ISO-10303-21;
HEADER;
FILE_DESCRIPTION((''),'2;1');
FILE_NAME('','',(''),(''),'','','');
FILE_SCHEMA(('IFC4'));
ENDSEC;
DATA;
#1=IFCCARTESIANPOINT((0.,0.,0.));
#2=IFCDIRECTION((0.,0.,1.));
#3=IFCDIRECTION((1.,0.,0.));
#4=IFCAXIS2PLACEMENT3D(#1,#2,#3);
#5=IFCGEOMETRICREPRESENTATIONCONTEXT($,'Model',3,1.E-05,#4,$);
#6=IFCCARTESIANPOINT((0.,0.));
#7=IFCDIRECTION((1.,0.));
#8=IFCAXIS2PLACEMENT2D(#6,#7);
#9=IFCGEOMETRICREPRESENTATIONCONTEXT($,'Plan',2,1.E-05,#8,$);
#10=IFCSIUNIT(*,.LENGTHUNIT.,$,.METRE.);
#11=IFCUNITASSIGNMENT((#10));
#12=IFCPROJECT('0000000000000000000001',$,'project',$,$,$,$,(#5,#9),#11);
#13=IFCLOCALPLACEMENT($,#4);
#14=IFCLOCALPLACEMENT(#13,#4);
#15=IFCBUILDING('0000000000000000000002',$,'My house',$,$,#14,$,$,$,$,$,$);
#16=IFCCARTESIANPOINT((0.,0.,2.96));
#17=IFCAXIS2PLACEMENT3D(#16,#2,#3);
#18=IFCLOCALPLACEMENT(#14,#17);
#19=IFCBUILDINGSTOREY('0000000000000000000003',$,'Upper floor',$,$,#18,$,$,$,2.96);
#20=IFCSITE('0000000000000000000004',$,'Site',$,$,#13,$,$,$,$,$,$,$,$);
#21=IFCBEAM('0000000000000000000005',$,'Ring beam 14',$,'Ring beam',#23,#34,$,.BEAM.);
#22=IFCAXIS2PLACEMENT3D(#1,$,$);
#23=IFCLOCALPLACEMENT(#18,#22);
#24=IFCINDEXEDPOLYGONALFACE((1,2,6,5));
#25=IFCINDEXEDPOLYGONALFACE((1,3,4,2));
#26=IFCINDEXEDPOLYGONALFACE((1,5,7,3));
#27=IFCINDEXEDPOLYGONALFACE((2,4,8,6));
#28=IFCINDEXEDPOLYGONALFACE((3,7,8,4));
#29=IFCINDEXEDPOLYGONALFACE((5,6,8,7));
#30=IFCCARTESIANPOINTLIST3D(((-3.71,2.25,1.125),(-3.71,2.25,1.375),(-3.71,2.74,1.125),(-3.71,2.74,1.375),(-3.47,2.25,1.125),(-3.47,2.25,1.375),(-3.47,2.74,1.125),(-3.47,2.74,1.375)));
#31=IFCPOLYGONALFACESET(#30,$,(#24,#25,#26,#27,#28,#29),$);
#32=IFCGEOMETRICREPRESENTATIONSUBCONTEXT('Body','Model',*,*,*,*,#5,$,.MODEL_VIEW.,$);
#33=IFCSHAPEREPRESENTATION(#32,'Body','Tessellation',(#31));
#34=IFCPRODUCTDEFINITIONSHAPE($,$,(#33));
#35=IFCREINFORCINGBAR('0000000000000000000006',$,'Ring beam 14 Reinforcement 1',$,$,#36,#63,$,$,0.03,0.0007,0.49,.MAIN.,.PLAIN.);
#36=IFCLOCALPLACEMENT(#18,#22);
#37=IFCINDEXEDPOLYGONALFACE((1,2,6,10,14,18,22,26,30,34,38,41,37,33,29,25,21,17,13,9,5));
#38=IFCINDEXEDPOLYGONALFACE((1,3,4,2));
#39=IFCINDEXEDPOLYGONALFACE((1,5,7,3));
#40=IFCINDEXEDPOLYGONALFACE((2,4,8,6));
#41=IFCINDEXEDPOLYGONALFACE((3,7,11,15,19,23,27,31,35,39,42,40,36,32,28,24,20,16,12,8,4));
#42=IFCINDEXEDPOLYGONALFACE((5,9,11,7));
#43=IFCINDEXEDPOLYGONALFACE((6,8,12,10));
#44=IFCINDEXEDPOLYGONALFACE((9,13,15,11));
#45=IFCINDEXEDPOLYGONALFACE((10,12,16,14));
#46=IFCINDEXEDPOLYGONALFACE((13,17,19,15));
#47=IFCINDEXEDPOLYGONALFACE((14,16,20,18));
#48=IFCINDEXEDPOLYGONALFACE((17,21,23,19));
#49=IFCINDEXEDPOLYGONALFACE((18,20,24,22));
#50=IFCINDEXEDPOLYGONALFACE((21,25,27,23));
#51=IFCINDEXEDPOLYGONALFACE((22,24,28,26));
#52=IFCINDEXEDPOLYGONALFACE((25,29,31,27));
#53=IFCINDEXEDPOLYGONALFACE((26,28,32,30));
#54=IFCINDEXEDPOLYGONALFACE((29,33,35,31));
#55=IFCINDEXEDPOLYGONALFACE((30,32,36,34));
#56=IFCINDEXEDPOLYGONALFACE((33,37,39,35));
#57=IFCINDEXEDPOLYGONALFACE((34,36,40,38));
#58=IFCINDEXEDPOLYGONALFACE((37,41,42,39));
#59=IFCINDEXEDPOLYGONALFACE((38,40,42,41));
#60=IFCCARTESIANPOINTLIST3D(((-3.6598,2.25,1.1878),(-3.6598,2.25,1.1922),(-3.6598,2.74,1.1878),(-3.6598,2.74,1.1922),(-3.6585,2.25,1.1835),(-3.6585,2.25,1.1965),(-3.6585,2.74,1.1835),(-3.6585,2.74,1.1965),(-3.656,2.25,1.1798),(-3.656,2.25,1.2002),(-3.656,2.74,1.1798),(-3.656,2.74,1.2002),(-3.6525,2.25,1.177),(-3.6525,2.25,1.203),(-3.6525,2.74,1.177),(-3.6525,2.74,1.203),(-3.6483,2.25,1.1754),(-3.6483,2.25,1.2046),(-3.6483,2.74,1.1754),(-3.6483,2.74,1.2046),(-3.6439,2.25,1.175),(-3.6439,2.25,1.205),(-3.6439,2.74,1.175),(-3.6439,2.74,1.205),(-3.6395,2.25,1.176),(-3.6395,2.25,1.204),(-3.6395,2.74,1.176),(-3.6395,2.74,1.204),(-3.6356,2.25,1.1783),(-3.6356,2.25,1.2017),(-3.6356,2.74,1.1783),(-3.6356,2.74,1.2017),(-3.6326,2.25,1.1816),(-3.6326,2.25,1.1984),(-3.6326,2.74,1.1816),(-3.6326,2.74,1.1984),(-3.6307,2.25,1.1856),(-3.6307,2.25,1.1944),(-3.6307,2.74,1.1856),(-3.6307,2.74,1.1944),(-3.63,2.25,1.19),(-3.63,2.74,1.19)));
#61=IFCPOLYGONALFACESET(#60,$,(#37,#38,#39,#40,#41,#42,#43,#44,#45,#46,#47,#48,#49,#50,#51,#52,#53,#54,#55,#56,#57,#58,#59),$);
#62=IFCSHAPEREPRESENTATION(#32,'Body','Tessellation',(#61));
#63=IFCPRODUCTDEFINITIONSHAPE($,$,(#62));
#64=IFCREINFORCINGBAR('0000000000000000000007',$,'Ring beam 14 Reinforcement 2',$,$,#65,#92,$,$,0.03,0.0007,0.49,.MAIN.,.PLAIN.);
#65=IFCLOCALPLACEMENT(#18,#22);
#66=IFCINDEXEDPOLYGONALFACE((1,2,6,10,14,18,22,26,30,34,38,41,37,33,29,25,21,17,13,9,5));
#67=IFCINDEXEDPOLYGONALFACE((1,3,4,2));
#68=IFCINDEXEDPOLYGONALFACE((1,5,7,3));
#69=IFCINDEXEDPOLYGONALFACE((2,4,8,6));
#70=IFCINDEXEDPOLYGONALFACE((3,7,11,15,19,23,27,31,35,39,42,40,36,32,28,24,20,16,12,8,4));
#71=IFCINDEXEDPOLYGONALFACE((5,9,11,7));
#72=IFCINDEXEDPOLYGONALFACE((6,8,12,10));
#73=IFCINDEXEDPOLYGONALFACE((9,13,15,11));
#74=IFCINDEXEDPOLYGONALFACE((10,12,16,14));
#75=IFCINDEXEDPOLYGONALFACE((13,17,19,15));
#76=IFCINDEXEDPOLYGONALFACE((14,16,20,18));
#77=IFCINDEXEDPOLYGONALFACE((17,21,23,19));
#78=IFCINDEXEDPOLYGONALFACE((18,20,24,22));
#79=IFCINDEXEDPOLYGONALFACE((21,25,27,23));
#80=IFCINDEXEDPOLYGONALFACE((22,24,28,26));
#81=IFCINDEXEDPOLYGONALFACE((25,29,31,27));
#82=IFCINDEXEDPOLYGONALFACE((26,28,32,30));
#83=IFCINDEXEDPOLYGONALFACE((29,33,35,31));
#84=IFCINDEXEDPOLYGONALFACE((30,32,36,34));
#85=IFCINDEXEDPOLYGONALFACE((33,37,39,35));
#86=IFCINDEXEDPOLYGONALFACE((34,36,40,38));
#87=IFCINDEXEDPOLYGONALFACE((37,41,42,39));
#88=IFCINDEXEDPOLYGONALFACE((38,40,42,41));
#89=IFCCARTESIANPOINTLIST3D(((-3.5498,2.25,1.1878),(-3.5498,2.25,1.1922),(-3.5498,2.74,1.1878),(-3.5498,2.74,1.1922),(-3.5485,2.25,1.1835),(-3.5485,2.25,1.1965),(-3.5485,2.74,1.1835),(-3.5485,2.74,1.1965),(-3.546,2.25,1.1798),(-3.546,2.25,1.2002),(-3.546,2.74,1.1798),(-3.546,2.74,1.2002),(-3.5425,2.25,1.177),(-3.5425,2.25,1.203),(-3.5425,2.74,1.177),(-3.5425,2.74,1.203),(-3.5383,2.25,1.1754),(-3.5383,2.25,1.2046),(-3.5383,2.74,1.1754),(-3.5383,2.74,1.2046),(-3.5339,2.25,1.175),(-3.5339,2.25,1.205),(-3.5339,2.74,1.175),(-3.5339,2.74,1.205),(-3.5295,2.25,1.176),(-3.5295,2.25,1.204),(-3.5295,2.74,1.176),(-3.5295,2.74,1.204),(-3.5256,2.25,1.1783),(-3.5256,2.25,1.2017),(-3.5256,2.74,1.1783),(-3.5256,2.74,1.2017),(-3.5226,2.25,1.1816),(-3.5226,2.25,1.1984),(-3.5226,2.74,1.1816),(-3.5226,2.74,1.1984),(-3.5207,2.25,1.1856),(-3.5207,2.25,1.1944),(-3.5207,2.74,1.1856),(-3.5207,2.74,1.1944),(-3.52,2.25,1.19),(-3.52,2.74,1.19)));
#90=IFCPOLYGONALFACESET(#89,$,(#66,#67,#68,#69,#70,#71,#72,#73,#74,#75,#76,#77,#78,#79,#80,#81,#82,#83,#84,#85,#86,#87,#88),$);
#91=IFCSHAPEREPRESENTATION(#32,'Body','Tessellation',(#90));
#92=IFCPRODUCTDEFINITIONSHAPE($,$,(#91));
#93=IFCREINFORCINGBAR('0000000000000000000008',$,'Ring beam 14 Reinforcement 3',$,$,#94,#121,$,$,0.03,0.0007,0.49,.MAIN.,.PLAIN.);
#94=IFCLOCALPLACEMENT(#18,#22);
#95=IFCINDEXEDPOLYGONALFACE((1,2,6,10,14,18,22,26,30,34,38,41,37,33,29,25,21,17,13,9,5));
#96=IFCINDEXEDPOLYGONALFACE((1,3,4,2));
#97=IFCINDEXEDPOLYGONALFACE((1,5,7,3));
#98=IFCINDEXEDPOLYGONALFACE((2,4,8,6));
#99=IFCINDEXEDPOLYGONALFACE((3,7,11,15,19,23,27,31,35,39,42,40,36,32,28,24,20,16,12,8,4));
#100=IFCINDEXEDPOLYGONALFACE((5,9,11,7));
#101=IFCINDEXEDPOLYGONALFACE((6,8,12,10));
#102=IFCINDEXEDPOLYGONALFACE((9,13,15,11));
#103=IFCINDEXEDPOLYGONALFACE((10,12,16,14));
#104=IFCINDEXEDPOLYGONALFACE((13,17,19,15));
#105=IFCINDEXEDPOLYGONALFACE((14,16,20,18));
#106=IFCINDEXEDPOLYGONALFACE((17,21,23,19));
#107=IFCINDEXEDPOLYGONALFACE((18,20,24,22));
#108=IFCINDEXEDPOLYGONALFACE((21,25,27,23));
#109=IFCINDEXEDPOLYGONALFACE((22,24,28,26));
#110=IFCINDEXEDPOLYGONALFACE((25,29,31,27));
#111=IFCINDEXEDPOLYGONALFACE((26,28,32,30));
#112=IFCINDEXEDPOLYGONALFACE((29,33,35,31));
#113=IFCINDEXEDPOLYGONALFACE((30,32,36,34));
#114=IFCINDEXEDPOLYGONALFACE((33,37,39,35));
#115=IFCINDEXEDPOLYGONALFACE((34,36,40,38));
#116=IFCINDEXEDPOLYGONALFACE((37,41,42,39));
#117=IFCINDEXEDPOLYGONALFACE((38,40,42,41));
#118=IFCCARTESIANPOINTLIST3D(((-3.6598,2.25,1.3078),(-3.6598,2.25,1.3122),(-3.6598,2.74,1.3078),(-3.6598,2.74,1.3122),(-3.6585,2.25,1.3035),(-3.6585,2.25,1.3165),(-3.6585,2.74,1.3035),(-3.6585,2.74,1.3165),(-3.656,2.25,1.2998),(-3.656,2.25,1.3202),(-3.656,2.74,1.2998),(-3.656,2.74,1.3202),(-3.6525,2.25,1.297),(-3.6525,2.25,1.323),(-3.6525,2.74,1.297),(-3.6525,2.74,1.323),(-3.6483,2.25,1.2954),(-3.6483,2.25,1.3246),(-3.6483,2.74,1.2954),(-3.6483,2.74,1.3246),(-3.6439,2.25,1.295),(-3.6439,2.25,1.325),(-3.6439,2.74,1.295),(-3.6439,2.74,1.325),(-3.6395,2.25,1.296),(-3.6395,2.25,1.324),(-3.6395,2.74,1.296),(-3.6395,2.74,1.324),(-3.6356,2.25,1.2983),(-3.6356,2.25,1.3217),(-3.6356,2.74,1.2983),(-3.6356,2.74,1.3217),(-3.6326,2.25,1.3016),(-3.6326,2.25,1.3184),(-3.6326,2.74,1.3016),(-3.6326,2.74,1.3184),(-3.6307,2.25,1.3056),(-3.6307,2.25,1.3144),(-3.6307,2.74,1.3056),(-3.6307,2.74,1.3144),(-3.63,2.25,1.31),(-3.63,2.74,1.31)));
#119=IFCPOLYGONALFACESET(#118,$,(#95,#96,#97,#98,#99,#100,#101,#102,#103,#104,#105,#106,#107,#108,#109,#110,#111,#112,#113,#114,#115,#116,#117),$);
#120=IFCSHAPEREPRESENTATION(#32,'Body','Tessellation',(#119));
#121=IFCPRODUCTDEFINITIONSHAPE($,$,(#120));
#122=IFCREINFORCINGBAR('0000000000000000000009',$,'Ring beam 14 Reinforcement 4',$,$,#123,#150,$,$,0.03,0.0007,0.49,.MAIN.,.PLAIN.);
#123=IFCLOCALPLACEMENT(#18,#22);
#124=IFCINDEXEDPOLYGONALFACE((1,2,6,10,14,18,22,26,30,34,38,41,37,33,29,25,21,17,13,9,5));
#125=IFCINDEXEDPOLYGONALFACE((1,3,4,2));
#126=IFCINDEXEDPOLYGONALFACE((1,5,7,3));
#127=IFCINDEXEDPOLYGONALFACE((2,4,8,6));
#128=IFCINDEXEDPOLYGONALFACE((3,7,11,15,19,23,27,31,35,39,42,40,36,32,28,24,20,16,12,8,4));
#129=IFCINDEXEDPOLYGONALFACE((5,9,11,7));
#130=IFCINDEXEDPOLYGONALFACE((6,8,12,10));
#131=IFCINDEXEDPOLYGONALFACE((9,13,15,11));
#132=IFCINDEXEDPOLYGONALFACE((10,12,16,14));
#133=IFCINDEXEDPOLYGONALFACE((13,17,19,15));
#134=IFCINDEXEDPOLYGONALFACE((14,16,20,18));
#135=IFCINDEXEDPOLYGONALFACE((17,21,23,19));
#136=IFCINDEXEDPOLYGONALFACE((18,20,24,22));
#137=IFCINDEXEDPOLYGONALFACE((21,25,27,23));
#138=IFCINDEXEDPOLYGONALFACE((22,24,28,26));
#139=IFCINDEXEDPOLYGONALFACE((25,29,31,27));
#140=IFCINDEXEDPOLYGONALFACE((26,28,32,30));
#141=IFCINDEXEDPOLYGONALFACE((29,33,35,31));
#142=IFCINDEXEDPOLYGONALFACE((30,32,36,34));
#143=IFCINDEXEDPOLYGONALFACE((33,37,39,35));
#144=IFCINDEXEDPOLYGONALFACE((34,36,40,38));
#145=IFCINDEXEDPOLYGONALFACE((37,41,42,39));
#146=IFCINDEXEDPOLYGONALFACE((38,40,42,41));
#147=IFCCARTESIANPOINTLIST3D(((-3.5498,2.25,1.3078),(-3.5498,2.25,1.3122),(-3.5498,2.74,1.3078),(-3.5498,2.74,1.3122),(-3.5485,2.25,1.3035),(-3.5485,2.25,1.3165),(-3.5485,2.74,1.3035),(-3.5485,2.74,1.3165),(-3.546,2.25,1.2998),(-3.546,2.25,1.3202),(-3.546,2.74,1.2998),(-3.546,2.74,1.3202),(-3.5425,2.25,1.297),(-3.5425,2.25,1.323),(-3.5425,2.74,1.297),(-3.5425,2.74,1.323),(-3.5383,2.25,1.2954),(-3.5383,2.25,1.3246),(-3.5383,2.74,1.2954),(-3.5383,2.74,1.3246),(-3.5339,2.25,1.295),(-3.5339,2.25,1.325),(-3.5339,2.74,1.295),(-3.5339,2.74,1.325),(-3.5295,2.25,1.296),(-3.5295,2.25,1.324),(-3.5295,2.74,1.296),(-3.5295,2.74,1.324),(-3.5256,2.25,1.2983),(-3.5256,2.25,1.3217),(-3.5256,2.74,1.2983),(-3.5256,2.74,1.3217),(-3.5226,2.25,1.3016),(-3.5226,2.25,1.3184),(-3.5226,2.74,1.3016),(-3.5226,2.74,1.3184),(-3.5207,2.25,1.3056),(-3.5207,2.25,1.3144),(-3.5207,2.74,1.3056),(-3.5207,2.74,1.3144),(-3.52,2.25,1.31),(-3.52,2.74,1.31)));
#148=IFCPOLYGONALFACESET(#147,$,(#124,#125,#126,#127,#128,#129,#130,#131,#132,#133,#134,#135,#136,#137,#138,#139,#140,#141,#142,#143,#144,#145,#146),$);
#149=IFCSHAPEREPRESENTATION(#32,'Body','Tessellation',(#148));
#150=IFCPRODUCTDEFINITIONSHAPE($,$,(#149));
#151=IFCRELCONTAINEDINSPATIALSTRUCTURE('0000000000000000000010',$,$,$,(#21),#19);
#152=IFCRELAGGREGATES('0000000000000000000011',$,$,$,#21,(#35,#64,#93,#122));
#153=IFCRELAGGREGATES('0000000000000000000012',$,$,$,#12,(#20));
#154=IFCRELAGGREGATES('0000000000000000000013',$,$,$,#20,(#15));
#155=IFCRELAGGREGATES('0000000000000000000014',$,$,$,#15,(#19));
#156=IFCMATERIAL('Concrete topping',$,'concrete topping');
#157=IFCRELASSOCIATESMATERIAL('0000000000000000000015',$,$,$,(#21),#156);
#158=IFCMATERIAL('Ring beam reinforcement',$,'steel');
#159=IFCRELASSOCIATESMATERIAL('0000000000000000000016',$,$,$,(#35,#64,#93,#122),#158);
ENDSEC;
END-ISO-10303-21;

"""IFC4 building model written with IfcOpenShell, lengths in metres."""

from ifc_helpers import new_model, si_unit, frame, origin_with_axes, origin_2d, origin_2d_with_axis, place, context, subcontext, project, spatial, circle_curve, rectangle, outline, extrude, source, transform, mapped, material, element, aggregate, save


model = new_model("IFC4")

# Units and contexts
model_context = context("Model", 3, precision=1e-05, world=origin_with_axes())
plan_context = context("Plan", 2, precision=1e-05, world=origin_2d_with_axis())
body_context = subcontext(model_context, "Body", "Model", "MODEL_VIEW")
ifc_project = project(units=[si_unit("LENGTHUNIT", "METRE")], contexts=[model_context, plan_context])

# Site, building, storey
site_placement = place(None, origin_with_axes())
site = spatial("IfcSite", under=ifc_project, at=site_placement, Name="Site")
building_placement = place(site_placement, origin_with_axes())
building = spatial("IfcBuilding", under=site, at=building_placement, Name="My house")
storey_placement = place(building_placement, frame((0.0, 0.0, 2.96), z_axis=(0.0, 0.0, 1.0), x_axis=(1.0, 0.0, 0.0)))
storey = spatial("IfcBuildingStorey", under=building, at=storey_placement, Name="Upper floor", Elevation=2.96)

# Beam
ifc_material_1 = material(Name="Concrete topping", Category="concrete topping")
shared_shape_1 = source(origin_with_axes(), body_context, "Body", "SweptSolid", [
    extrude(rectangle(XDim=0.24, YDim=0.25), frame((0.0, 0.0, 0.0), z_axis=(1.0, 0.0, 0.0), x_axis=(0.0, 1.0, 0.0)), (0.0, 0.0, 1.0), 0.49),
])
beam_1_placement = place(storey_placement, frame((-3.59, 2.25, 1.25), z_axis=(0.0, 0.0, 1.0), x_axis=(0.0, -1.0, 0.0)))
beam_1 = element("IfcBeam", 1, at=beam_1_placement, inside=storey, material=ifc_material_1, Name="Ring beam 14", ObjectType="Ring beam", PredefinedType="BEAM", context=body_context, shape_type="MappedRepresentation", body=[
    mapped(shared_shape_1, transform((0.0, 0.0, 0.0), x_axis=(-1.0, 0.0, 0.0), y_axis=(0.0, 1.0, 0.0), z_axis=(0.0, 0.0, 1.0), scale=1.0)),
])

# Reinforcing bars
ifc_material_2 = material(Name="Ring beam reinforcement", Category="steel")
shared_shape_2 = source(origin_with_axes(), body_context, "Body", "SweptSolid", [
    extrude(outline(circle_curve(origin_2d(), 0.015)), frame((0.0, 0.0, 0.0), z_axis=(1.0, 0.0, 0.0), x_axis=(0.0, 1.0, 0.0)), (0.0, 0.0, 1.0), 0.49),
])
reinforcing_bar_1_placement = place(beam_1_placement, frame((0.0, -0.055, -0.06), z_axis=(0.0, 0.0, 1.0), x_axis=(1.0, 0.0, 0.0)))
reinforcing_bar_1 = element("IfcReinforcingBar", 2, at=reinforcing_bar_1_placement, material=ifc_material_2, Name="Ring beam 14 Reinforcement 1", BarLength=0.49, BarSurface="PLAIN", CrossSectionArea=0.0007, NominalDiameter=0.03, PredefinedType="MAIN", context=body_context, shape_type="MappedRepresentation", body=[
    mapped(shared_shape_2, transform((0.0, 0.0, 0.0), x_axis=(-1.0, 0.0, 0.0), y_axis=(0.0, 1.0, 0.0), z_axis=(0.0, 0.0, 1.0), scale=1.0)),
])
shared_shape_3 = source(origin_with_axes(), body_context, "Body", "SweptSolid", [
    extrude(outline(circle_curve(origin_2d(), 0.015)), frame((0.0, 0.0, 0.0), z_axis=(1.0, 0.0, 0.0), x_axis=(0.0, 1.0, 0.0)), (0.0, 0.0, 1.0), 0.49),
])
reinforcing_bar_2_placement = place(beam_1_placement, frame((0.0, 0.055, -0.06), z_axis=(0.0, 0.0, 1.0), x_axis=(1.0, 0.0, 0.0)))
reinforcing_bar_2 = element("IfcReinforcingBar", 3, at=reinforcing_bar_2_placement, material=ifc_material_2, Name="Ring beam 14 Reinforcement 2", BarLength=0.49, BarSurface="PLAIN", CrossSectionArea=0.0007, NominalDiameter=0.03, PredefinedType="MAIN", context=body_context, shape_type="MappedRepresentation", body=[
    mapped(shared_shape_3, transform((0.0, 0.0, 0.0), x_axis=(-1.0, 0.0, 0.0), y_axis=(0.0, 1.0, 0.0), z_axis=(0.0, 0.0, 1.0), scale=1.0)),
])
shared_shape_4 = source(origin_with_axes(), body_context, "Body", "SweptSolid", [
    extrude(outline(circle_curve(origin_2d(), 0.015)), frame((0.0, 0.0, 0.0), z_axis=(1.0, 0.0, 0.0), x_axis=(0.0, 1.0, 0.0)), (0.0, 0.0, 1.0), 0.49),
])
reinforcing_bar_3_placement = place(beam_1_placement, frame((0.0, -0.055, 0.06), z_axis=(0.0, 0.0, 1.0), x_axis=(1.0, 0.0, 0.0)))
reinforcing_bar_3 = element("IfcReinforcingBar", 4, at=reinforcing_bar_3_placement, material=ifc_material_2, Name="Ring beam 14 Reinforcement 3", BarLength=0.49, BarSurface="PLAIN", CrossSectionArea=0.0007, NominalDiameter=0.03, PredefinedType="MAIN", context=body_context, shape_type="MappedRepresentation", body=[
    mapped(shared_shape_4, transform((0.0, 0.0, 0.0), x_axis=(-1.0, 0.0, 0.0), y_axis=(0.0, 1.0, 0.0), z_axis=(0.0, 0.0, 1.0), scale=1.0)),
])
shared_shape_5 = source(origin_with_axes(), body_context, "Body", "SweptSolid", [
    extrude(outline(circle_curve(origin_2d(), 0.015)), frame((0.0, 0.0, 0.0), z_axis=(1.0, 0.0, 0.0), x_axis=(0.0, 1.0, 0.0)), (0.0, 0.0, 1.0), 0.49),
])
reinforcing_bar_4_placement = place(beam_1_placement, frame((0.0, 0.055, 0.06), z_axis=(0.0, 0.0, 1.0), x_axis=(1.0, 0.0, 0.0)))
reinforcing_bar_4 = element("IfcReinforcingBar", 5, at=reinforcing_bar_4_placement, material=ifc_material_2, Name="Ring beam 14 Reinforcement 4", BarLength=0.49, BarSurface="PLAIN", CrossSectionArea=0.0007, NominalDiameter=0.03, PredefinedType="MAIN", context=body_context, shape_type="MappedRepresentation", body=[
    mapped(shared_shape_5, transform((0.0, 0.0, 0.0), x_axis=(-1.0, 0.0, 0.0), y_axis=(0.0, 1.0, 0.0), z_axis=(0.0, 0.0, 1.0), scale=1.0)),
])
aggregate(beam_1, [reinforcing_bar_1, reinforcing_bar_2, reinforcing_bar_3, reinforcing_bar_4])

save(model, "model.ifc")
